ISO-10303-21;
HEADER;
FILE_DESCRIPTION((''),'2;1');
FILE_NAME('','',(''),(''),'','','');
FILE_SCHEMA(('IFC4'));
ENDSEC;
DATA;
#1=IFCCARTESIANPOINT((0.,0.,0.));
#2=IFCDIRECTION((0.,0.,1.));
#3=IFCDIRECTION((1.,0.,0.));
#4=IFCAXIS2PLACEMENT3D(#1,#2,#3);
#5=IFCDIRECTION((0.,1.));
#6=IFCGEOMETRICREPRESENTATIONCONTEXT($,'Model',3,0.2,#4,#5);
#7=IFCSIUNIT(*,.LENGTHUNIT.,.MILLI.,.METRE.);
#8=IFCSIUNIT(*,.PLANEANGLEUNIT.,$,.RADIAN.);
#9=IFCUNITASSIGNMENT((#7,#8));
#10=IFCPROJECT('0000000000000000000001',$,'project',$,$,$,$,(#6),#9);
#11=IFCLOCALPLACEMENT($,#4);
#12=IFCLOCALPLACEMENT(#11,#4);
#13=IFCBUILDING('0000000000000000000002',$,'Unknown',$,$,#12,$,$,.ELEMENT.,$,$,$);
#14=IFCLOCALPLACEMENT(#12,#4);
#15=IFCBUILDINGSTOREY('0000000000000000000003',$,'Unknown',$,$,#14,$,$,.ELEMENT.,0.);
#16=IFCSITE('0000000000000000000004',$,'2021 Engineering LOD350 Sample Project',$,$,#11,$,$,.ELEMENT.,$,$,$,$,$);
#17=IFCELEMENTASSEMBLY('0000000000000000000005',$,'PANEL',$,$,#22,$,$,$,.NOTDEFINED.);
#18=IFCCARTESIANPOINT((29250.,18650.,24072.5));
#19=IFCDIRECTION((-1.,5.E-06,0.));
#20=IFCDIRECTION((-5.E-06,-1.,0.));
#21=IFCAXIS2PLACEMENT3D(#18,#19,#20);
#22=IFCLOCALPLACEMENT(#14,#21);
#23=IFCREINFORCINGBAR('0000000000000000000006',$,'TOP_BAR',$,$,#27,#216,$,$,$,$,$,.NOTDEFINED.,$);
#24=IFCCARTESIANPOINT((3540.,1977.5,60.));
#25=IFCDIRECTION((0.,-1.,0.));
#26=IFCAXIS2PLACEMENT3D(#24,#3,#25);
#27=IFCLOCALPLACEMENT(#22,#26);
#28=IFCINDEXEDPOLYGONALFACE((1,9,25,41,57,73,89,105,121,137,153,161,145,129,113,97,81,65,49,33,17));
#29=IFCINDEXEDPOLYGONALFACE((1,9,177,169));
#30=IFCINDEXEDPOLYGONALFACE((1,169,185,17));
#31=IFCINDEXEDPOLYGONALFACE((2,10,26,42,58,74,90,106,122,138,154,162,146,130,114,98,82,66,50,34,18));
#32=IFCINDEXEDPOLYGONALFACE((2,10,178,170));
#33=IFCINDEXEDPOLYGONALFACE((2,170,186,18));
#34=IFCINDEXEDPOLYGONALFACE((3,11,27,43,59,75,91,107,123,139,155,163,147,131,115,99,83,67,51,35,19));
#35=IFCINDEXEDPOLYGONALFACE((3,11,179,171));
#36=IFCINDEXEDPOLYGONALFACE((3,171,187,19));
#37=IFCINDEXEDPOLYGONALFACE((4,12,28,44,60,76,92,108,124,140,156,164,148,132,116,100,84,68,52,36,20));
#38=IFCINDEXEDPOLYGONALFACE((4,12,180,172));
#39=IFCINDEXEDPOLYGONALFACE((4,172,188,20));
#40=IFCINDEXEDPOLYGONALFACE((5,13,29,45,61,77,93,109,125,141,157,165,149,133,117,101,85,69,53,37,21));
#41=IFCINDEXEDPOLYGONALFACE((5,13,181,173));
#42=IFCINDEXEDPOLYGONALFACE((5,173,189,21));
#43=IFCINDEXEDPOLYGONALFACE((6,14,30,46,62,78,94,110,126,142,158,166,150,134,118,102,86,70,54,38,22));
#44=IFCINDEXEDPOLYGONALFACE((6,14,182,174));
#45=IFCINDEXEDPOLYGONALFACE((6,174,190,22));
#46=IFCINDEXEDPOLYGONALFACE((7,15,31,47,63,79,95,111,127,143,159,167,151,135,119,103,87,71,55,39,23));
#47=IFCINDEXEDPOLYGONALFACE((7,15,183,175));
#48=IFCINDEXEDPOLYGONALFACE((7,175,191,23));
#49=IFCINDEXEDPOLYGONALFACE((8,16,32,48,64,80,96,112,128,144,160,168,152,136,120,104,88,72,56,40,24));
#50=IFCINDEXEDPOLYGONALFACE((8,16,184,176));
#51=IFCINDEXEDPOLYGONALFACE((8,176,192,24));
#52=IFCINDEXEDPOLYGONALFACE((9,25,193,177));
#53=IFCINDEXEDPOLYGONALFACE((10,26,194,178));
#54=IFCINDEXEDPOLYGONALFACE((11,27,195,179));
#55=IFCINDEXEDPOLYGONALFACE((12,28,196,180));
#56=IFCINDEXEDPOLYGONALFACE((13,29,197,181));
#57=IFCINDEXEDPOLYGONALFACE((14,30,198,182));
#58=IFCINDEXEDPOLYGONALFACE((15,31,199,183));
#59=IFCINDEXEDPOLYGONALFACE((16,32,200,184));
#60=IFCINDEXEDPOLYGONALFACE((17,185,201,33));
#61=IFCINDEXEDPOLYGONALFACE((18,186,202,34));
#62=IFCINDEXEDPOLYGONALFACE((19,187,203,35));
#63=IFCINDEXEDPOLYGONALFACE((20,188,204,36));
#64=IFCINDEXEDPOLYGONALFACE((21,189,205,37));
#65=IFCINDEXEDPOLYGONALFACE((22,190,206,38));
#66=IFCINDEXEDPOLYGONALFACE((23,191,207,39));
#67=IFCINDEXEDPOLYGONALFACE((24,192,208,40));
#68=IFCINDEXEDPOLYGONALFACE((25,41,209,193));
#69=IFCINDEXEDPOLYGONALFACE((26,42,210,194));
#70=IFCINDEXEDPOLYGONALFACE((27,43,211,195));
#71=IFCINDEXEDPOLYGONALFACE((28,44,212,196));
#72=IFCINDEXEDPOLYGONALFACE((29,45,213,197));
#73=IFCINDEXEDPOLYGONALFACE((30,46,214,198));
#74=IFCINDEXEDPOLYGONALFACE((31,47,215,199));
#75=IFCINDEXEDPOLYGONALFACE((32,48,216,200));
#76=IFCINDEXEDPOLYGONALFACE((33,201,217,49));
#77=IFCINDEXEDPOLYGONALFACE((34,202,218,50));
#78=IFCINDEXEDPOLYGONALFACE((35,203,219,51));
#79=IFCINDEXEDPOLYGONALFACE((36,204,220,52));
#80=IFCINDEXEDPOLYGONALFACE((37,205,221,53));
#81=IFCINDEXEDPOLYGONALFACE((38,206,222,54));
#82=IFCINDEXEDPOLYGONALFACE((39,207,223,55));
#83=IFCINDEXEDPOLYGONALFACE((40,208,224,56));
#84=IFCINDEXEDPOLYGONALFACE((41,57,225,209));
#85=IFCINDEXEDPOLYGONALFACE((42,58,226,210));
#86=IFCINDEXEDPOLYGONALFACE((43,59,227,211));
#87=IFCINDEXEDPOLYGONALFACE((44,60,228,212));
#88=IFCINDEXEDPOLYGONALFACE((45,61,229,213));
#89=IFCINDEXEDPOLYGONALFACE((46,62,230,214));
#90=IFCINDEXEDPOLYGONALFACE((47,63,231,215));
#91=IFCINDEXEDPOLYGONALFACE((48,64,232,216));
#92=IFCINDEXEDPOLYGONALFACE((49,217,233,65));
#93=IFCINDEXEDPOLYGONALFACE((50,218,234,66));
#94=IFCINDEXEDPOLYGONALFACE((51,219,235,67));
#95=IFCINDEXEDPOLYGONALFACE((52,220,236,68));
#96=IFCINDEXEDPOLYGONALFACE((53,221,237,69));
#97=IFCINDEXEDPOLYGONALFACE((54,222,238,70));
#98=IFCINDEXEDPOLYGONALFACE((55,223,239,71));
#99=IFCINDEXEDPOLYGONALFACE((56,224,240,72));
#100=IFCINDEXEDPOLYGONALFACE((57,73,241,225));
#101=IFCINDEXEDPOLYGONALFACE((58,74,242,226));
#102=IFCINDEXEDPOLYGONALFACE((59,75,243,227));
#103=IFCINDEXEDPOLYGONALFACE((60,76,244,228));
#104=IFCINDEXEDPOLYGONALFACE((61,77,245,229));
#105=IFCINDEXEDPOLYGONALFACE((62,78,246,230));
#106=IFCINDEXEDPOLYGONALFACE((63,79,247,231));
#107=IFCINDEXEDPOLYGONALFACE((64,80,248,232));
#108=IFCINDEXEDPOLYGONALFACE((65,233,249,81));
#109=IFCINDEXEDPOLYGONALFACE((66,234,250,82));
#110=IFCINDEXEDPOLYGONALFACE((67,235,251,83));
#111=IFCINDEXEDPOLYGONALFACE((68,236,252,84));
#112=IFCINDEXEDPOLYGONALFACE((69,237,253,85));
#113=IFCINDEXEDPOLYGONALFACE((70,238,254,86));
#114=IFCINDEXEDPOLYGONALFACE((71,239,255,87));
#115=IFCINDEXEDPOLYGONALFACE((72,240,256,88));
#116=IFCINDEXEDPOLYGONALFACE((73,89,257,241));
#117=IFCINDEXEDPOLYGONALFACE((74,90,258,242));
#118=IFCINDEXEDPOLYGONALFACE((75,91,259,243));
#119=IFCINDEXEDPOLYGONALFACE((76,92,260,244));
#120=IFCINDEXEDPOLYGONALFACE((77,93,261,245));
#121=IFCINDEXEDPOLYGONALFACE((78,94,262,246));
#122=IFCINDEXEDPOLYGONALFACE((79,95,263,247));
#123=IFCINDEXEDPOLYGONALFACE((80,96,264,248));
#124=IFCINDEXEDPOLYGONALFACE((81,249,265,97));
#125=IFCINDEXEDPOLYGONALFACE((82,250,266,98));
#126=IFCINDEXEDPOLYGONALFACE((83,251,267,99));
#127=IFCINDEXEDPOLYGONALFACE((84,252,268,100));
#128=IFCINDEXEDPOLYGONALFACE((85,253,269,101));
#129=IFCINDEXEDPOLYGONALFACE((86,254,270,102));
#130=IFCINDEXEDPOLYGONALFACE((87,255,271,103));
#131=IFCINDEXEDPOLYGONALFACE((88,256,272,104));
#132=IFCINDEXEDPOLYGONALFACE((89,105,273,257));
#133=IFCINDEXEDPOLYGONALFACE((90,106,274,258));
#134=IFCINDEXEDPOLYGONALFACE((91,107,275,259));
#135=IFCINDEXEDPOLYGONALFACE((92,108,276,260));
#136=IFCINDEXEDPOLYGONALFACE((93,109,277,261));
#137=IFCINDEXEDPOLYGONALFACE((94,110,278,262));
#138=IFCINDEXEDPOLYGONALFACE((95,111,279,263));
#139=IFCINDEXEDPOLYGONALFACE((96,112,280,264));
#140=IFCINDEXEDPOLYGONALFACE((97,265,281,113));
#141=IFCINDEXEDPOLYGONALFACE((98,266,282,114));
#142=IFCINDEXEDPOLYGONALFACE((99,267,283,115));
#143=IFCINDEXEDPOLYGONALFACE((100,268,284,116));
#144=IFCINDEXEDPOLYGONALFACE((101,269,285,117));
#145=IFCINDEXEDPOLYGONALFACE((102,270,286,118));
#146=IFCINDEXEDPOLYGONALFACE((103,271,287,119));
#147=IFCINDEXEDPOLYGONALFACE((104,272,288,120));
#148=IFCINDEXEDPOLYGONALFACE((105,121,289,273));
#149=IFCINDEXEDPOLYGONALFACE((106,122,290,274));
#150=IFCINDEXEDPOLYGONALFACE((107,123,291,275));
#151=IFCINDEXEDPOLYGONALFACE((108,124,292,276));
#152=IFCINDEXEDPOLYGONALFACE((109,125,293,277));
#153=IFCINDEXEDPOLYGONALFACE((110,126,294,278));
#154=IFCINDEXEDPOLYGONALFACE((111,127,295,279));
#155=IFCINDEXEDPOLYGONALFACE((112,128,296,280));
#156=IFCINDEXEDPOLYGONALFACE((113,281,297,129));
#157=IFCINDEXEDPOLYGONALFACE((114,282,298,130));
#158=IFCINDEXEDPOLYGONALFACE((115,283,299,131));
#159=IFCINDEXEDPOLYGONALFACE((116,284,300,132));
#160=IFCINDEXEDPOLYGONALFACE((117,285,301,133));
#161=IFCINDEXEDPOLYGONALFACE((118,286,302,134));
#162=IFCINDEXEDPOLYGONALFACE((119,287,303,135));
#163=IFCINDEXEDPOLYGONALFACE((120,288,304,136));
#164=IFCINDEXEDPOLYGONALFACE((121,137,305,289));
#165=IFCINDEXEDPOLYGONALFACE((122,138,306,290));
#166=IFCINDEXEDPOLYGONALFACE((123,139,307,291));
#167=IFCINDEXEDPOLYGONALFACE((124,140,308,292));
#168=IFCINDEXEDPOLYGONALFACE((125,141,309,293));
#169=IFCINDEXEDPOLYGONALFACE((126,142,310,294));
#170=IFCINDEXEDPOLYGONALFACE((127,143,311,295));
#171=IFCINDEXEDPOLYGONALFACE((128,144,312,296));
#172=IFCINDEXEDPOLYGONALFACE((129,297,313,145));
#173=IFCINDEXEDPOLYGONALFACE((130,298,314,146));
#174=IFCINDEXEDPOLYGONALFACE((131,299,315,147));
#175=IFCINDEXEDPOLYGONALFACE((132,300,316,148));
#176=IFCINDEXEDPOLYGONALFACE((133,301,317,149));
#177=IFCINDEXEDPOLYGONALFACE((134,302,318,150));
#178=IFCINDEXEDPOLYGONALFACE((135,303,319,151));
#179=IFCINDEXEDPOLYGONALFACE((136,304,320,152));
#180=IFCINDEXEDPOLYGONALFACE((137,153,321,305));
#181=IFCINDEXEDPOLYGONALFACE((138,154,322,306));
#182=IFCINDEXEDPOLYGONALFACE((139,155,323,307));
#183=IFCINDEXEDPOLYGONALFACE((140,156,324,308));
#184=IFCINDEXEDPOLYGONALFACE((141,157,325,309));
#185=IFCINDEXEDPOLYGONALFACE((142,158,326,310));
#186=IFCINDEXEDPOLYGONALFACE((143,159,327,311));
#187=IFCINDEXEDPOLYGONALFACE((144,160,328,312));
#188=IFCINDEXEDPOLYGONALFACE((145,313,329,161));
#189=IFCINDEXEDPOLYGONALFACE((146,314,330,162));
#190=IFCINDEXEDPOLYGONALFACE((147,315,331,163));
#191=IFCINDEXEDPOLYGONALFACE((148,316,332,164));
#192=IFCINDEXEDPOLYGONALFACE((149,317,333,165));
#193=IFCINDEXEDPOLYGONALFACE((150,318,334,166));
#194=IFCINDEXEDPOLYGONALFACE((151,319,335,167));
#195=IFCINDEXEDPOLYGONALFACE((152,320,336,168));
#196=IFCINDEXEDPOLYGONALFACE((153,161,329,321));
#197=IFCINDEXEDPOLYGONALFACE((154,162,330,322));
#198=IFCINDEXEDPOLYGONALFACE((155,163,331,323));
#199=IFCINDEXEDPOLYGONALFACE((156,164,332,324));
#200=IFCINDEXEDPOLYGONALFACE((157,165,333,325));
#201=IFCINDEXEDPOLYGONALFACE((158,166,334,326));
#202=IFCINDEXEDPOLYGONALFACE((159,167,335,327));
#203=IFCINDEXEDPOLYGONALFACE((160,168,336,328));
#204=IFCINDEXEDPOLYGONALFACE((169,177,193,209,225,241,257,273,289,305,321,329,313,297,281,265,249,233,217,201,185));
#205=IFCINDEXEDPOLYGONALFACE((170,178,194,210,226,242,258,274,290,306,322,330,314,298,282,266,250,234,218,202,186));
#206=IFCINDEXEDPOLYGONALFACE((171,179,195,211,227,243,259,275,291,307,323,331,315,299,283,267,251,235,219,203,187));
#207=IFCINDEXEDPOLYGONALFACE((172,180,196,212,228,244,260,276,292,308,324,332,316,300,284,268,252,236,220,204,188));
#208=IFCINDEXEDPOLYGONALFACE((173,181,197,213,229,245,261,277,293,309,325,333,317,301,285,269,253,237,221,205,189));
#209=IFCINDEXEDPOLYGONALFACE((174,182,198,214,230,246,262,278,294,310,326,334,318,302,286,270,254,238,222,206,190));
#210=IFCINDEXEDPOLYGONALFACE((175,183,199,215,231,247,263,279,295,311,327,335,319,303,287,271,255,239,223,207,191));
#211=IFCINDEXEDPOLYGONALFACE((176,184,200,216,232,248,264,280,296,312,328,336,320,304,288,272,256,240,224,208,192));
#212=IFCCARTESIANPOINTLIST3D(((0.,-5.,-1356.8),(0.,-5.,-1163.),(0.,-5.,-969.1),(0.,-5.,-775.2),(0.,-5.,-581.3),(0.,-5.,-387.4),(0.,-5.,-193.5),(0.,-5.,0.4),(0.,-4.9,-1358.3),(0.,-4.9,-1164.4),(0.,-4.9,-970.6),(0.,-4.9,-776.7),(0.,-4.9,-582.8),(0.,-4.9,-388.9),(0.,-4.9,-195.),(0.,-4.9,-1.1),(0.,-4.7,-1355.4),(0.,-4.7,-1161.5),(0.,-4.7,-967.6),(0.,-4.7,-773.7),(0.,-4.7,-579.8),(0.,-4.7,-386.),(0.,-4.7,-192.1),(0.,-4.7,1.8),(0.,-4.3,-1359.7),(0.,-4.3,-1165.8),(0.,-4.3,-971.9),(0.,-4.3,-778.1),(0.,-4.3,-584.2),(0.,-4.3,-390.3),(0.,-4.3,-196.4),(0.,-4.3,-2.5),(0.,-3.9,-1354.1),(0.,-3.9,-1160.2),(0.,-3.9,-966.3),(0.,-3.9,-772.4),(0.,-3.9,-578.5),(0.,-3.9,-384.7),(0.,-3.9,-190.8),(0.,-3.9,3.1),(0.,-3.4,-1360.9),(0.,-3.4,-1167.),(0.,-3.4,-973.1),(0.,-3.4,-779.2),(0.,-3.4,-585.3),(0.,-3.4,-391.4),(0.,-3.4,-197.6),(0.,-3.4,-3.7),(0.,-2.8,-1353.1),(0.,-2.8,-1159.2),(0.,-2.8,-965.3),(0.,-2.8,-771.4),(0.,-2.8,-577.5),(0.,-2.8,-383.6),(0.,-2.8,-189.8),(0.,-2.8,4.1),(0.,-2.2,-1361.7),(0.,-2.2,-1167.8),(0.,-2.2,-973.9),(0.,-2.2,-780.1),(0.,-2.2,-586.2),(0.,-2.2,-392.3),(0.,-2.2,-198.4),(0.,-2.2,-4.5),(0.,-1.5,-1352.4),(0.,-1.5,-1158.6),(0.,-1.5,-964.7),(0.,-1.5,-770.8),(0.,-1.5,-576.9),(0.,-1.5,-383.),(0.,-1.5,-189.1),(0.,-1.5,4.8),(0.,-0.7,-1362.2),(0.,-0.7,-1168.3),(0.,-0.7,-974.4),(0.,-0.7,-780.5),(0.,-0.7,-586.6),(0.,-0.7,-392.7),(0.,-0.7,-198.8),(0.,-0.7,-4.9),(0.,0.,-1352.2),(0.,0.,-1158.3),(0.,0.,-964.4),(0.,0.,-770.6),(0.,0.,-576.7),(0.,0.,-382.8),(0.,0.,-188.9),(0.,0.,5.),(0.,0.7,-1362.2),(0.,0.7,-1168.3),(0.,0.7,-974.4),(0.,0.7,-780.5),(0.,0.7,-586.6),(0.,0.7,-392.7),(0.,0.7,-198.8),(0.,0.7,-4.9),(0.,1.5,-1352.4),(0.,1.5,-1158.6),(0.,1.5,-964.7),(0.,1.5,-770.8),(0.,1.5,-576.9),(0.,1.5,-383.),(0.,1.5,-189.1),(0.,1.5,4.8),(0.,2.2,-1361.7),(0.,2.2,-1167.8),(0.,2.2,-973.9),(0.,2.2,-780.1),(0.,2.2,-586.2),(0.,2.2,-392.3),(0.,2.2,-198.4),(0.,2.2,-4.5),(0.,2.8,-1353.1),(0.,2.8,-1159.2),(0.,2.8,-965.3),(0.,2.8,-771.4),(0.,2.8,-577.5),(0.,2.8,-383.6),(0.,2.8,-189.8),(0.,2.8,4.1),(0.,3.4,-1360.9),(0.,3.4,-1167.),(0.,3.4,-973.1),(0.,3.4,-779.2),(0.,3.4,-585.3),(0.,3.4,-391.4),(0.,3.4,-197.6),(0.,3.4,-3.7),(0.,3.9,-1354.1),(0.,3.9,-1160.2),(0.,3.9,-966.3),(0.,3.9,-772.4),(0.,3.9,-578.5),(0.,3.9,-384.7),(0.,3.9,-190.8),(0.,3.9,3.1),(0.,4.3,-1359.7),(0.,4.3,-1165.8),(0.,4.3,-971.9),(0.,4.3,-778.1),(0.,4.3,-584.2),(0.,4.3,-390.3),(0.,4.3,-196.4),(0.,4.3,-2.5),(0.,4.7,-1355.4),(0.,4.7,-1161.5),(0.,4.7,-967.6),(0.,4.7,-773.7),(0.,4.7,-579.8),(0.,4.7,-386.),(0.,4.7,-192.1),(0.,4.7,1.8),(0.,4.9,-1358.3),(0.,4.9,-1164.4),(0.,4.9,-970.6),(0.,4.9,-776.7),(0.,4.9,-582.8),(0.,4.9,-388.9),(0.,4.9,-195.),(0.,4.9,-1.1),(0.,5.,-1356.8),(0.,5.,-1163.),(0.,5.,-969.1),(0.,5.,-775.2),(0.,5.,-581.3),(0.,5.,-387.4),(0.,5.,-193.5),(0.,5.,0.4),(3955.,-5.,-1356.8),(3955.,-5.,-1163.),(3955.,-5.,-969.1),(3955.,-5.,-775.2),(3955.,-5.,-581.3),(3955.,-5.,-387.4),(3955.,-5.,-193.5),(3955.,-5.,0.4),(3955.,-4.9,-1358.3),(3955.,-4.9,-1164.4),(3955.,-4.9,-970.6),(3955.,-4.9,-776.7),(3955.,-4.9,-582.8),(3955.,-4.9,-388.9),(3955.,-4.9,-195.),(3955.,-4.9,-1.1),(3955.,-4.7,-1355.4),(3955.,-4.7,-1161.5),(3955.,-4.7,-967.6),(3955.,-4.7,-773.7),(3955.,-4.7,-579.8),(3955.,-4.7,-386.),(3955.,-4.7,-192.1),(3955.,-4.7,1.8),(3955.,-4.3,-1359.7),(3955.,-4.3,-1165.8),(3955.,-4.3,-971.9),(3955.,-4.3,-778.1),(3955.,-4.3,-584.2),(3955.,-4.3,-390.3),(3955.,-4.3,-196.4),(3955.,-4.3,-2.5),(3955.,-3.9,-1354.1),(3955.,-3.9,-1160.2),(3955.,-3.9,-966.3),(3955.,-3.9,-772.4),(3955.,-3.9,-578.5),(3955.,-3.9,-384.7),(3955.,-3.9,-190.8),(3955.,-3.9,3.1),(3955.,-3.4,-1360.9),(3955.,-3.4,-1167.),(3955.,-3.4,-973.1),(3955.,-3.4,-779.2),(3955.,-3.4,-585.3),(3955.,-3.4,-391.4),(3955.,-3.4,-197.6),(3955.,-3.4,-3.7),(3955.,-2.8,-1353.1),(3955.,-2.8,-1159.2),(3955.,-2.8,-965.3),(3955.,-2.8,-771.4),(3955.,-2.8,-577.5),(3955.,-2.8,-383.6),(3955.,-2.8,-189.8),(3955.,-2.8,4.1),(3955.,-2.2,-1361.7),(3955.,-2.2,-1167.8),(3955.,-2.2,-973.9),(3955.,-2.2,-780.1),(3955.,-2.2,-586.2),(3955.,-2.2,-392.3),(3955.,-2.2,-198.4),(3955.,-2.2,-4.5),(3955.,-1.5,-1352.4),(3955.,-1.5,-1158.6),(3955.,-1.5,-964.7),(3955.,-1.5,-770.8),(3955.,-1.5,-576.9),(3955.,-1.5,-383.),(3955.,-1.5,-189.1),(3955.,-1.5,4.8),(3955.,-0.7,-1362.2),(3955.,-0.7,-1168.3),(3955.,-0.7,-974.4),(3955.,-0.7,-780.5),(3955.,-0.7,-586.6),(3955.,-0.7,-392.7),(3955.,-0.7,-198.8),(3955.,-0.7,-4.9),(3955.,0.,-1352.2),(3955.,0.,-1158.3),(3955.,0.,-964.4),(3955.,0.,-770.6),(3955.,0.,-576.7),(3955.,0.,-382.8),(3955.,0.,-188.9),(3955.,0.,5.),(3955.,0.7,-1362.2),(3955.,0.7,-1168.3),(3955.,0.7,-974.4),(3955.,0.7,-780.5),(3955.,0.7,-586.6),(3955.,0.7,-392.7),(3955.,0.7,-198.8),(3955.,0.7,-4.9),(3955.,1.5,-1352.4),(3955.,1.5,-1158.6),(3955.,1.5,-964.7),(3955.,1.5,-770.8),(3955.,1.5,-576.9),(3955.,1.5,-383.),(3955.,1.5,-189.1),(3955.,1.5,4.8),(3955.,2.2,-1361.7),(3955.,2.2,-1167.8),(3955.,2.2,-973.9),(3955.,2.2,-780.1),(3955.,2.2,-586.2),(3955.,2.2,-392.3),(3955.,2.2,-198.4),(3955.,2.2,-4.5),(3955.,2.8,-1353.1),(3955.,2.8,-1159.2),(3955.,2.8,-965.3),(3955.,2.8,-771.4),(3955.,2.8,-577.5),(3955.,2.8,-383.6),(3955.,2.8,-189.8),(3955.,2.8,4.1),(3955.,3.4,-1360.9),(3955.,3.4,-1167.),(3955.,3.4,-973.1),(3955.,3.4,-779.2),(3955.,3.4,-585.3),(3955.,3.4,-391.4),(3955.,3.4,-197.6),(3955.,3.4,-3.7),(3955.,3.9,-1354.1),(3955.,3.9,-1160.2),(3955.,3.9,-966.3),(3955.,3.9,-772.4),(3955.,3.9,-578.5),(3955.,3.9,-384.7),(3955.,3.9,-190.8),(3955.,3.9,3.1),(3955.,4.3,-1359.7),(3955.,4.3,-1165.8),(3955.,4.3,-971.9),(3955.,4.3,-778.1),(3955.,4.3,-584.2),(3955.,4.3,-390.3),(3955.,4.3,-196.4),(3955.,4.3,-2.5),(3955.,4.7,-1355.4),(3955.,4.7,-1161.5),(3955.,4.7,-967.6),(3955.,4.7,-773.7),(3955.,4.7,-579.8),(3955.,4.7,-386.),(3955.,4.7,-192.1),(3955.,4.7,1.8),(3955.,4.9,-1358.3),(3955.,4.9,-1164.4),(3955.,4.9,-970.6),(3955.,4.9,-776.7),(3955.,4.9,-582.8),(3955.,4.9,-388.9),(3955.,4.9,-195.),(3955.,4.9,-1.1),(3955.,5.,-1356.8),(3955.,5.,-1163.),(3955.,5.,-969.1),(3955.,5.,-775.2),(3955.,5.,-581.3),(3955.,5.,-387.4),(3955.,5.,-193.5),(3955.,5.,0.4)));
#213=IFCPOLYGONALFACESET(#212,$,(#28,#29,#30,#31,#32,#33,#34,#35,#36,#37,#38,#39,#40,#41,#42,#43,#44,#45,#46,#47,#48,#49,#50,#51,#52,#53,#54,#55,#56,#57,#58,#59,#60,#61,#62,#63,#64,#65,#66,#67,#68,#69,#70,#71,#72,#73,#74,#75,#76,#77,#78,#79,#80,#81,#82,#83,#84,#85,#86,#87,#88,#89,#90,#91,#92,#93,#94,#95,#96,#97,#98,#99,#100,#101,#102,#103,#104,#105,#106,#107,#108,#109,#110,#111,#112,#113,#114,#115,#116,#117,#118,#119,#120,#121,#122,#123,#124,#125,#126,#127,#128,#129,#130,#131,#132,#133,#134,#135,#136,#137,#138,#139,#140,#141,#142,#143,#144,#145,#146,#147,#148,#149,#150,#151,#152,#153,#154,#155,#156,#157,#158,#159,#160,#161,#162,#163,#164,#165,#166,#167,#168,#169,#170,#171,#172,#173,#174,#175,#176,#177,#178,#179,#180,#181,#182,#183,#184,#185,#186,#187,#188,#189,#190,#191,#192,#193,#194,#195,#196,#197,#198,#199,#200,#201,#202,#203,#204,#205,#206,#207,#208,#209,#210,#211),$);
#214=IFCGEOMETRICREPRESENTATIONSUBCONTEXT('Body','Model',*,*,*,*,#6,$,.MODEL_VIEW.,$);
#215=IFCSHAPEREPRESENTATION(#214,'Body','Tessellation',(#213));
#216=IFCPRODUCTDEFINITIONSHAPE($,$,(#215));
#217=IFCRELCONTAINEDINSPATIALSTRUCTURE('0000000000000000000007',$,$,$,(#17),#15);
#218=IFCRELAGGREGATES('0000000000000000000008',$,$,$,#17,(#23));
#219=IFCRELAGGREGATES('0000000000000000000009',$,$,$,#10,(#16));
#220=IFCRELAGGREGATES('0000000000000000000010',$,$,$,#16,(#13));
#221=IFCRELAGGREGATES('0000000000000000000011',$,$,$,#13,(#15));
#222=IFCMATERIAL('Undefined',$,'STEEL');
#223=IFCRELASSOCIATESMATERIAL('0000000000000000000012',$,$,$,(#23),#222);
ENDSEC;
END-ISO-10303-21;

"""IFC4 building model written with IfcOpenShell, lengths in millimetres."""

from ifc_helpers import new_model, entity, si_unit, direction, frame, origin_with_axes, place, context, subcontext, project, spatial, source, transform, mapped, material, element, aggregate, save


model = new_model("IFC4")

# Units and contexts
model_context = context("Model", 3, precision=0.2, world=origin_with_axes(), true_north=direction((0.0, 1.0)))
body_context = subcontext(model_context, "Body", "Model", "MODEL_VIEW")
ifc_project = project(units=[si_unit("LENGTHUNIT", "METRE", prefix="MILLI"), si_unit("PLANEANGLEUNIT", "RADIAN")], contexts=[model_context])

# Site, building, storey
site_placement = place(None, origin_with_axes())
site = spatial("IfcSite", under=ifc_project, at=site_placement, Name="2021 Engineering LOD350 Sample Project", CompositionType="ELEMENT")
building_placement = place(site_placement, origin_with_axes())
building = spatial("IfcBuilding", under=site, at=building_placement, Name="Unknown", CompositionType="ELEMENT")
storey_placement = place(building_placement, origin_with_axes())
storey = spatial("IfcBuildingStorey", under=building, at=storey_placement, Name="Unknown", CompositionType="ELEMENT", Elevation=0.0)

# Element assembly
assembly_1_placement = place(storey_placement, frame((29250.0, 18650.0, 24072.5), z_axis=(-1.0, 0.000005, 0.0), x_axis=(-0.000005, -1.0, 0.0)))
assembly_1 = element("IfcElementAssembly", 1, at=assembly_1_placement, inside=storey, Name="PANEL", PredefinedType="NOTDEFINED")
ifc_material_1 = material(Name="Undefined", Category="STEEL")

# Reinforcing bar
shared_shape_1 = source(origin_with_axes(), body_context, "Body", "AdvancedSweptSolid", [
    entity("IfcSweptDiskSolid", entity("IfcIndexedPolyCurve", entity("IfcCartesianPointList3D", [[0.0, 0.0, 0.0], [3955.0, 0.0, 0.0]]), [entity("IfcLineIndex", [1, 2])]), 5.0),
])
reinforcing_bar_1_placement = place(assembly_1_placement, frame((3540.0, 1977.5, 60.0), z_axis=(1.0, 0.0, 0.0), x_axis=(0.0, -1.0, 0.0)))
reinforcing_bar_1 = element("IfcReinforcingBar", 2, at=reinforcing_bar_1_placement, material=ifc_material_1, Name="TOP_BAR", PredefinedType="NOTDEFINED", context=body_context, shape_type="MappedRepresentation", body=[
    mapped(shared_shape_1, transform((0.0, 0.0, 0.0))),
    mapped(shared_shape_1, transform((0.0, 0.0, -193.9))),
    mapped(shared_shape_1, transform((0.0, 0.0, -387.8))),
    mapped(shared_shape_1, transform((0.0, 0.0, -581.7))),
    mapped(shared_shape_1, transform((0.0, 0.0, -775.6))),
    mapped(shared_shape_1, transform((0.0, 0.0, -969.4))),
    mapped(shared_shape_1, transform((0.0, 0.0, -1163.3))),
    mapped(shared_shape_1, transform((0.0, 0.0, -1357.2))),
])
aggregate(assembly_1, [reinforcing_bar_1])

save(model, "model.ifc")
